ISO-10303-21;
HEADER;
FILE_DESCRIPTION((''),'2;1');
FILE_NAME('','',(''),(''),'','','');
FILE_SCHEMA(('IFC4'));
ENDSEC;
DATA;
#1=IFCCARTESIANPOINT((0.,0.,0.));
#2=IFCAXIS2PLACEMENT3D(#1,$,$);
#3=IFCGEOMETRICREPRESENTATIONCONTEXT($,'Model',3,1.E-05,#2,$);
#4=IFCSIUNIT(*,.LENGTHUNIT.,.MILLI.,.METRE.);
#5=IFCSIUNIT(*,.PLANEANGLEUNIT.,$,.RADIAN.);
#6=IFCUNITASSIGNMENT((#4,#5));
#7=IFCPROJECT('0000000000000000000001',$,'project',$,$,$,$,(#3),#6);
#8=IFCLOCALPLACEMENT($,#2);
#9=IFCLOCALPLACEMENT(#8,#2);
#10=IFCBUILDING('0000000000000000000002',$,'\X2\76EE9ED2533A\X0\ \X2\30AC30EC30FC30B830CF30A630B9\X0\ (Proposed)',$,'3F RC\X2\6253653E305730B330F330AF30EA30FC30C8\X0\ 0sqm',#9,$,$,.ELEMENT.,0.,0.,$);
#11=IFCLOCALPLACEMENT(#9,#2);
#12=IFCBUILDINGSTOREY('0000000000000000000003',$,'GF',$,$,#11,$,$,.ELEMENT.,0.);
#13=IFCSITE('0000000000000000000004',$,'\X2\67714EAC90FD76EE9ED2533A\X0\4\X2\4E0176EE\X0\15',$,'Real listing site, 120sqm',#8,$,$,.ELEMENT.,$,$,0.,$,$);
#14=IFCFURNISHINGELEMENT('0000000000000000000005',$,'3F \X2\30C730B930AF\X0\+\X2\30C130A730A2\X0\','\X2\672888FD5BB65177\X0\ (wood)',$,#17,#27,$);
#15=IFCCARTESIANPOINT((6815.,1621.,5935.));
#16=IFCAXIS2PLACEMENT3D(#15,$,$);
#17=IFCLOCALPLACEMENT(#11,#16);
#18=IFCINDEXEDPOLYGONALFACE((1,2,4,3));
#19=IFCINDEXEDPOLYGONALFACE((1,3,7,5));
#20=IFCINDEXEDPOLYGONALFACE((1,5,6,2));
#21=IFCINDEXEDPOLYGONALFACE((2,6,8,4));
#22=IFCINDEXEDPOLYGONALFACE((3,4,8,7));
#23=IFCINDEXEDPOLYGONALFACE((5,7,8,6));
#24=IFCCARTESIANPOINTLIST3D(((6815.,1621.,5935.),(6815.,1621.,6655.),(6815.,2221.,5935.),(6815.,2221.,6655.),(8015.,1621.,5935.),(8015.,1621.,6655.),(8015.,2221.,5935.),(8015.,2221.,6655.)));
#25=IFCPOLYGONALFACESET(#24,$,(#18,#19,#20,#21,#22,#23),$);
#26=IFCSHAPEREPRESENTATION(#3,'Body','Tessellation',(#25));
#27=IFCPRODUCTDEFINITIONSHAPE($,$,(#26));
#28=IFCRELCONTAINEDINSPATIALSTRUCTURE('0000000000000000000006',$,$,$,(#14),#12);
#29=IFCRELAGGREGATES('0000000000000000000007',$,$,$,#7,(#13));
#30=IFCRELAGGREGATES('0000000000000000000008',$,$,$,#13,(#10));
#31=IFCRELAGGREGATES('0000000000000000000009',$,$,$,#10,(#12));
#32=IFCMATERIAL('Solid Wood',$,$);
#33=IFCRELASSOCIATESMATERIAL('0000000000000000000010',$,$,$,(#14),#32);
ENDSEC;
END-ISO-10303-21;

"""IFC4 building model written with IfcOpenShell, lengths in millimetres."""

from ifc_helpers import new_model, si_unit, frame, frame_2d, origin, place, context, project, spatial, rectangle, extrude, material, element, save


model = new_model("IFC4")

# Units and contexts
model_context = context("Model", 3, precision=1e-05, world=origin())
ifc_project = project(units=[si_unit("LENGTHUNIT", "METRE", prefix="MILLI"), si_unit("PLANEANGLEUNIT", "RADIAN")], contexts=[model_context])

# Site, building, storey
site_placement = place(None, origin())
site = spatial("IfcSite", under=ifc_project, at=site_placement, Name="東京都目黒区4丁目15", ObjectType="Real listing site, 120sqm", CompositionType="ELEMENT", RefElevation=0.0)
building_placement = place(site_placement, origin())
building = spatial("IfcBuilding", under=site, at=building_placement, Name="目黒区 ガレージハウス (Proposed)", ObjectType="3F RC打放しコンクリート 0sqm", CompositionType="ELEMENT", ElevationOfRefHeight=0.0, ElevationOfTerrain=0.0)
storey_placement = place(building_placement, origin())
storey = spatial("IfcBuildingStorey", under=building, at=storey_placement, Name="GF", CompositionType="ELEMENT", Elevation=0.0)

# Shared definitions
ifc_material_1 = material(Name="Solid Wood")

# Furnishing element
furnishing_1_placement = place(storey_placement, frame((6815.0, 1621.0, 5935.0)))
element("IfcFurnishingElement", 1, at=furnishing_1_placement, inside=storey, material=ifc_material_1, Name="3F デスク+チェア", Description="木製家具 (wood)", context=model_context, shape_type="SweptSolid", body=[
    extrude(rectangle(XDim=1200.0, YDim=600.0, at=frame_2d((600.0, 300.0))), frame((6815.0, 1621.0, 5935.0)), (0.0, 0.0, 1.0), 720.0),
])

save(model, "model.ifc")
